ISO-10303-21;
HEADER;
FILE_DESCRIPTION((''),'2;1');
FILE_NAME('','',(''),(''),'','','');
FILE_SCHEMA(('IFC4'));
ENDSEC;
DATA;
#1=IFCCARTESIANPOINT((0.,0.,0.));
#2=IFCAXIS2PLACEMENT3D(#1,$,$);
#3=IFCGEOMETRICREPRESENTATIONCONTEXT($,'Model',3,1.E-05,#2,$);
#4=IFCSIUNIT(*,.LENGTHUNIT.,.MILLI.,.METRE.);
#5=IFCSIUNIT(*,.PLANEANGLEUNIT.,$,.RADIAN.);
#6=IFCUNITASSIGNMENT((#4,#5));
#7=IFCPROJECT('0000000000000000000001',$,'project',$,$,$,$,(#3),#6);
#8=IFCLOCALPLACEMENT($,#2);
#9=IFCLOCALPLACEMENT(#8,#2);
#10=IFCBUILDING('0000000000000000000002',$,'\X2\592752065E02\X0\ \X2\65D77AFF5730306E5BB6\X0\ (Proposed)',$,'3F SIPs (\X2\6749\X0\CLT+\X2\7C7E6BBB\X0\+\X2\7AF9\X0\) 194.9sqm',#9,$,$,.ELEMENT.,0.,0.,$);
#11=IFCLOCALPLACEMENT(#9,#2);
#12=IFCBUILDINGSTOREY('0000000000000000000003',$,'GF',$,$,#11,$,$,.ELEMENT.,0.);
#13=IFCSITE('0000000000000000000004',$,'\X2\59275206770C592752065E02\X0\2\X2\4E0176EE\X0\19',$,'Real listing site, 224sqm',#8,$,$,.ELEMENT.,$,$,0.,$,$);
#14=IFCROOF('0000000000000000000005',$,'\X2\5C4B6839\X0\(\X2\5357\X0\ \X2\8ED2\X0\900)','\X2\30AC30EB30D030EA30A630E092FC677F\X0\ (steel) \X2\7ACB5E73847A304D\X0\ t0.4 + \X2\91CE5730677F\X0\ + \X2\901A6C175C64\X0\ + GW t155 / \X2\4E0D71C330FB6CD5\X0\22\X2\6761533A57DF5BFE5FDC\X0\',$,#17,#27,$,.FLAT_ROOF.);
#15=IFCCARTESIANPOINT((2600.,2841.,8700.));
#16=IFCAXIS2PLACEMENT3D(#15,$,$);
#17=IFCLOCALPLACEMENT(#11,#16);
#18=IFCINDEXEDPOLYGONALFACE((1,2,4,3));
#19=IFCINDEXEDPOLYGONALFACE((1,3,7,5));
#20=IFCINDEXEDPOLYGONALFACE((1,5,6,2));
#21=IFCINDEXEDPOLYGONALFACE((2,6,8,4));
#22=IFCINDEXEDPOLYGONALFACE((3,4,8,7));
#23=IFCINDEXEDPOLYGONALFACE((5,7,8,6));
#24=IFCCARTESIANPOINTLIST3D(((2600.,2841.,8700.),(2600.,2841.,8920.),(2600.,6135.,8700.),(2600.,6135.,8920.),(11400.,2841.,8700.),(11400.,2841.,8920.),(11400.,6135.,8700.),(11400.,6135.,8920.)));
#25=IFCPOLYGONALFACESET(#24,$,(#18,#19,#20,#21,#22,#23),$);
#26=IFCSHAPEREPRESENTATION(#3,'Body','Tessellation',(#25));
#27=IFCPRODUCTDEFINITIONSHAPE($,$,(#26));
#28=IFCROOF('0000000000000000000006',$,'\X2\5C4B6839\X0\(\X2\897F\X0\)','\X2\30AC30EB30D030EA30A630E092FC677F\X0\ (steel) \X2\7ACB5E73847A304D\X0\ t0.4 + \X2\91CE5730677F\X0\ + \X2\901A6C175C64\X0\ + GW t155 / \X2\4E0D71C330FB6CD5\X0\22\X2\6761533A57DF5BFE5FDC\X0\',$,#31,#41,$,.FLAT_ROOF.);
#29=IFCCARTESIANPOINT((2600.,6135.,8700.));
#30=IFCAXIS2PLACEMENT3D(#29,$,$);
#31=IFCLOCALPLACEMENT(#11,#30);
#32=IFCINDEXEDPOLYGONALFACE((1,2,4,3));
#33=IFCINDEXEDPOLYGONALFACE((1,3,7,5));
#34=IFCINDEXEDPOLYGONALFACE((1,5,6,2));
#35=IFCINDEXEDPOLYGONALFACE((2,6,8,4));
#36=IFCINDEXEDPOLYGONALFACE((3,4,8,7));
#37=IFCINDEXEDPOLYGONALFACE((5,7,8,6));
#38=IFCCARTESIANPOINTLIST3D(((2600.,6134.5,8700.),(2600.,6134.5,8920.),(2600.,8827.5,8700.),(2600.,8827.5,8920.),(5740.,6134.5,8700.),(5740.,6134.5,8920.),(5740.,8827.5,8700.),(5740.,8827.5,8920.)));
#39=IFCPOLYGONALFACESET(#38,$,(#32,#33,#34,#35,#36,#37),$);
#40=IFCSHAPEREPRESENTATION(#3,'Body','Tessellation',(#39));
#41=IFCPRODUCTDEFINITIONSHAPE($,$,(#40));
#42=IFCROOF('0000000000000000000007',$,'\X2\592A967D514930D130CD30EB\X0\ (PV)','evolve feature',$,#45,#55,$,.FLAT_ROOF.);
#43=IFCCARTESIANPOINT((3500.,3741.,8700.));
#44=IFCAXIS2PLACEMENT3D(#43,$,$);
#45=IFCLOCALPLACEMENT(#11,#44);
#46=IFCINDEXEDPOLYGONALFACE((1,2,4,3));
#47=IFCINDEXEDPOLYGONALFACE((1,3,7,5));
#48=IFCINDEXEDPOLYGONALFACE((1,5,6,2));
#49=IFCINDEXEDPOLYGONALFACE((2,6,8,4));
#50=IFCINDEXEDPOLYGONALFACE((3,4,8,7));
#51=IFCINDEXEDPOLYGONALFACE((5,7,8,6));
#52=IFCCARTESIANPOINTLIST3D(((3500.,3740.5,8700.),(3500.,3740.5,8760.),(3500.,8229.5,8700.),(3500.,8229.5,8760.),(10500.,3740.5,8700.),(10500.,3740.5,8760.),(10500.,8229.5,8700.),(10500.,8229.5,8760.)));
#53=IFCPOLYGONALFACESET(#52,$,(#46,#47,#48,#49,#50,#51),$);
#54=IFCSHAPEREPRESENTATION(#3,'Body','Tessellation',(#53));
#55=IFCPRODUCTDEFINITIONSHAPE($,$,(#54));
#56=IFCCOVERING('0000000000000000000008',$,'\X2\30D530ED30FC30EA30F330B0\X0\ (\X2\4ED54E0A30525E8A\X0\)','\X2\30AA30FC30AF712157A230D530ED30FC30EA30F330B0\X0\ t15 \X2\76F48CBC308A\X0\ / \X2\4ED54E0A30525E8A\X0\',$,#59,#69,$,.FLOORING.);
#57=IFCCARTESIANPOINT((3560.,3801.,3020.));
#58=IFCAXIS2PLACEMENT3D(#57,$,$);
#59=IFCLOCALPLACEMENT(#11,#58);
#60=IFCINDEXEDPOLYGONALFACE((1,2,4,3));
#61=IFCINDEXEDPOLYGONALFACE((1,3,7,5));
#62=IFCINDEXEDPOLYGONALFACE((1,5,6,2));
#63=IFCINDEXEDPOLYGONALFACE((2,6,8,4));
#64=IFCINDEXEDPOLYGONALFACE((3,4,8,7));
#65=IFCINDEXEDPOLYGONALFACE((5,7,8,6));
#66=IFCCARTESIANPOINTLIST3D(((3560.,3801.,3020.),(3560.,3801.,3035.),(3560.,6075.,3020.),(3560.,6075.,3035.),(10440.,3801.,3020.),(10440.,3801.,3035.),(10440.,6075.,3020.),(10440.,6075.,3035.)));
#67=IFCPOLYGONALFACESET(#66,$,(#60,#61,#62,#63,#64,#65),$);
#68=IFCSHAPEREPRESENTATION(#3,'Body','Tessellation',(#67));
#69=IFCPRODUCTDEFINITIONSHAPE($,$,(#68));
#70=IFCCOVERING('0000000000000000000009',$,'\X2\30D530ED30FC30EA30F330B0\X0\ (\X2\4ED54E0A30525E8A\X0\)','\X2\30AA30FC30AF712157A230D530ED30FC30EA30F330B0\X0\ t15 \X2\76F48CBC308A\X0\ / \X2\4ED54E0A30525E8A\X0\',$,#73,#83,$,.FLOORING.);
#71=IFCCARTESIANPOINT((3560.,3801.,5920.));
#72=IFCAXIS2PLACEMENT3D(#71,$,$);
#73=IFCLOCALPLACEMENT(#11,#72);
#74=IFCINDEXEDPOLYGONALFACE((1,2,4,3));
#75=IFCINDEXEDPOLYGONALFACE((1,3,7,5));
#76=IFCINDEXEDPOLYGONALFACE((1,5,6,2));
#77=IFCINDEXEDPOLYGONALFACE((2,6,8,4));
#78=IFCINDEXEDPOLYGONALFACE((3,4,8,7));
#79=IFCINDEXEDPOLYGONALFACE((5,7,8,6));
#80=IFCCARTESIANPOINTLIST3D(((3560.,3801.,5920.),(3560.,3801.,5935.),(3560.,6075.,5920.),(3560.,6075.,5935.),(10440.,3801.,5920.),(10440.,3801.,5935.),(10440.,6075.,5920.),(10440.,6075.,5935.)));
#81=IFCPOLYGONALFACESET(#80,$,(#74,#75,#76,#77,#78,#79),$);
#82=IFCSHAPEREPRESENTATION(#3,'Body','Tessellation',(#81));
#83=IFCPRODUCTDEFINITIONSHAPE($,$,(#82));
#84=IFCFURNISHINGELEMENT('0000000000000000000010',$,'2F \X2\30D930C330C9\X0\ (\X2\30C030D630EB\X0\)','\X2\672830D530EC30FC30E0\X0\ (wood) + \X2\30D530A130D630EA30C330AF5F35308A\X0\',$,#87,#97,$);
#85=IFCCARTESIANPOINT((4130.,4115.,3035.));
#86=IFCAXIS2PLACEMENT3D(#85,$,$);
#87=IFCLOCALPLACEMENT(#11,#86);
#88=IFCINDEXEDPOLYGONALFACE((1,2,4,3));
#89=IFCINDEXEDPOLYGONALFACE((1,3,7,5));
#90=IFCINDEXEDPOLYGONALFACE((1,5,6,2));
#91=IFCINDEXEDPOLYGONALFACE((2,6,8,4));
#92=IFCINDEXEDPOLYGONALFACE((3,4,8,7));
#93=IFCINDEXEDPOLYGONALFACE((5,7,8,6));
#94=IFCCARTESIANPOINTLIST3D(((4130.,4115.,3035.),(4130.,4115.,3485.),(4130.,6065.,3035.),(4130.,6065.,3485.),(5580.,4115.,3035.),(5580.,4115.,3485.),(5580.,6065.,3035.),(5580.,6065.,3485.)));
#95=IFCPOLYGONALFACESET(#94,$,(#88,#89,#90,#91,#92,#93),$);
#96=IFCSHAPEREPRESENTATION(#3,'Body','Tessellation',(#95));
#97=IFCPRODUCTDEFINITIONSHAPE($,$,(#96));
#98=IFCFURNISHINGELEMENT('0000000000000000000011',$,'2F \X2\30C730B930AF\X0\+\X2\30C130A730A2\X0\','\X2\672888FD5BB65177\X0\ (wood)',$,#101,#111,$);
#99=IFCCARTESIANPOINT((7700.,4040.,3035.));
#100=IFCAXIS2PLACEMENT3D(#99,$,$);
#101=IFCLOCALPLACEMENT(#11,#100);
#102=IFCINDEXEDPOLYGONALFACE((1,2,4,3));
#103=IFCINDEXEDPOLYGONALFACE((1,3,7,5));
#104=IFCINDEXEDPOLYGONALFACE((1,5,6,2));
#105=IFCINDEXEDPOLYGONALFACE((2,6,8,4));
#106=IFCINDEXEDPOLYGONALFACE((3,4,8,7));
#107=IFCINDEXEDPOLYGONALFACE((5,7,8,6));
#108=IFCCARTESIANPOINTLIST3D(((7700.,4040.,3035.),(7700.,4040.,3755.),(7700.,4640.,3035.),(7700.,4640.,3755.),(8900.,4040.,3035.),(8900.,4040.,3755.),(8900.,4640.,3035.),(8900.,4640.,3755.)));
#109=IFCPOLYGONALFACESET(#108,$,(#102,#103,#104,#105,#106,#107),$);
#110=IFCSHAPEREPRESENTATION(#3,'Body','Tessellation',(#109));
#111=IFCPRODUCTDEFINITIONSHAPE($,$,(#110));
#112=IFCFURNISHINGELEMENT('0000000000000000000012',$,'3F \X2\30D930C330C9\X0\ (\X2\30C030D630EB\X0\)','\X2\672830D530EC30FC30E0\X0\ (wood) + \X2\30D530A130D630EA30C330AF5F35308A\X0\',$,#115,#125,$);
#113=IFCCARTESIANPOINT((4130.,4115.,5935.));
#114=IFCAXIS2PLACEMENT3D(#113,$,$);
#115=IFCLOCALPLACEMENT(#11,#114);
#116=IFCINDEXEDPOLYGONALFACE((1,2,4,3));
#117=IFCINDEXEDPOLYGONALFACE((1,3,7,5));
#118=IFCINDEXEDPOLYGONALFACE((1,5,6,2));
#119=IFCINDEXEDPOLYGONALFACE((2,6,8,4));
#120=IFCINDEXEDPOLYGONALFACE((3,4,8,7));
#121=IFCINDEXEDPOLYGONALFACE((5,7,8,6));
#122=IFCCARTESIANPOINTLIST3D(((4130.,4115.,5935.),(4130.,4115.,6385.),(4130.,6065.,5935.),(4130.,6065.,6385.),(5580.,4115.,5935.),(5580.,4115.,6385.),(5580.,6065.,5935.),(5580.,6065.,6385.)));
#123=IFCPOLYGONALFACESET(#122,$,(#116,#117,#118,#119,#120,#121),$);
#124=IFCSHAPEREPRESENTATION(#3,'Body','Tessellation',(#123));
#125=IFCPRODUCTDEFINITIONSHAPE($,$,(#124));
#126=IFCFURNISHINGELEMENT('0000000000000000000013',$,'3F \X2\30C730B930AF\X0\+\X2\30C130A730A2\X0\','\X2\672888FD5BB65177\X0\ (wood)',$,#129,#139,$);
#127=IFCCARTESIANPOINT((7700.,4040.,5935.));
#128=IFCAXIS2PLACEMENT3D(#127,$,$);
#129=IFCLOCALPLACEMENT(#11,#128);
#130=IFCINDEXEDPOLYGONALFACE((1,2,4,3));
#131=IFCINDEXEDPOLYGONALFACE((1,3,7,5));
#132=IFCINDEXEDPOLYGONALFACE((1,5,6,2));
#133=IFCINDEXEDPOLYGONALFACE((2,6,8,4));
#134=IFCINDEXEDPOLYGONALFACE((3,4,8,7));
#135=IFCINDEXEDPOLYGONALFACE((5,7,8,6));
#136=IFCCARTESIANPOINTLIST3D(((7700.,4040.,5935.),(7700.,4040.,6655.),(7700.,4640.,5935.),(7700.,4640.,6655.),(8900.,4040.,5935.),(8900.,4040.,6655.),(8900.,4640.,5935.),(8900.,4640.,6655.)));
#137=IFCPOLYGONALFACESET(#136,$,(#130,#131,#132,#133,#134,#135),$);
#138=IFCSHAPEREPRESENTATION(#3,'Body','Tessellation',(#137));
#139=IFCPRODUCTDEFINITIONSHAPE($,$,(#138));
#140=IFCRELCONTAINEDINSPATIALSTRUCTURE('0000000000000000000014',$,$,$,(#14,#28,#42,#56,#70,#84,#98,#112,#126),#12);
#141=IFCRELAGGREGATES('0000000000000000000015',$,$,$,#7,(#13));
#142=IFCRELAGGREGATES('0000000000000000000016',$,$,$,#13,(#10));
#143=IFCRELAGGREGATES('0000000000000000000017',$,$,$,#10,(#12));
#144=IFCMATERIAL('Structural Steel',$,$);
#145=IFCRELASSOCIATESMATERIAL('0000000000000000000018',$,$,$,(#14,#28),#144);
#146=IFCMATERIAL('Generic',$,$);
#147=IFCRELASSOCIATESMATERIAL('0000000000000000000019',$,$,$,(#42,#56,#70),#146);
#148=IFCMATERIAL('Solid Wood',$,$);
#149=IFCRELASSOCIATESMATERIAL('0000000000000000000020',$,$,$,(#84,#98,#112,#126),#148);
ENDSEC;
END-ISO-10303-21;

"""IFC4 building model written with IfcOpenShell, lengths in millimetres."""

from ifc_helpers import new_model, si_unit, frame, frame_2d, origin, place, context, project, spatial, rectangle, extrude, material, element, save


model = new_model("IFC4")

# Units and contexts
model_context = context("Model", 3, precision=1e-05, world=origin())
ifc_project = project(units=[si_unit("LENGTHUNIT", "METRE", prefix="MILLI"), si_unit("PLANEANGLEUNIT", "RADIAN")], contexts=[model_context])

# Site, building, storey
site_placement = place(None, origin())
site = spatial("IfcSite", under=ifc_project, at=site_placement, Name="大分県大分市2丁目19", ObjectType="Real listing site, 224sqm", CompositionType="ELEMENT", RefElevation=0.0)
building_placement = place(site_placement, origin())
building = spatial("IfcBuilding", under=site, at=building_placement, Name="大分市 旗竿地の家 (Proposed)", ObjectType="3F SIPs (杉CLT+籾殻+竹) 194.9sqm", CompositionType="ELEMENT", ElevationOfRefHeight=0.0, ElevationOfTerrain=0.0)
storey_placement = place(building_placement, origin())
storey = spatial("IfcBuildingStorey", under=building, at=storey_placement, Name="GF", CompositionType="ELEMENT", Elevation=0.0)

# Shared definitions
ifc_material_1 = material(Name="Solid Wood")

# Roofs
ifc_material_2 = material(Name="Structural Steel")
roof_1_placement = place(storey_placement, frame((2600.0, 2841.0, 8700.0)))
element("IfcRoof", 1, at=roof_1_placement, inside=storey, material=ifc_material_2, Name="屋根(南 軒900)", Description="ガルバリウム鋼板 (steel) 立平葺き t0.4 + 野地板 + 通気層 + GW t155 / 不燃・法22条区域対応", PredefinedType="FLAT_ROOF", context=model_context, shape_type="SweptSolid", body=[
    extrude(rectangle(XDim=8800.0, YDim=3294.0, at=frame_2d((4400.0, 1647.0))), frame((2600.0, 2841.0, 8700.0)), (0.0, 0.0, 1.0), 220.0),
])
roof_2_placement = place(storey_placement, frame((2600.0, 6135.0, 8700.0)))
element("IfcRoof", 2, at=roof_2_placement, inside=storey, material=ifc_material_2, Name="屋根(西)", Description="ガルバリウム鋼板 (steel) 立平葺き t0.4 + 野地板 + 通気層 + GW t155 / 不燃・法22条区域対応", PredefinedType="FLAT_ROOF", context=model_context, shape_type="SweptSolid", body=[
    extrude(rectangle(XDim=3140.0, YDim=2693.0, at=frame_2d((1570.0, 1346.0))), frame((2600.0, 6135.0, 8700.0)), (0.0, 0.0, 1.0), 220.0),
])
ifc_material_3 = material(Name="Generic")
roof_3_placement = place(storey_placement, frame((3500.0, 3741.0, 8700.0)))
element("IfcRoof", 3, at=roof_3_placement, inside=storey, material=ifc_material_3, Name="太陽光パネル (PV)", Description="evolve feature", PredefinedType="FLAT_ROOF", context=model_context, shape_type="SweptSolid", body=[
    extrude(rectangle(XDim=7000.0, YDim=4489.0, at=frame_2d((3500.0, 2244.0))), frame((3500.0, 3741.0, 8700.0)), (0.0, 0.0, 1.0), 60.0),
])

# Coverings
covering_1_placement = place(storey_placement, frame((3560.0, 3801.0, 3020.0)))
element("IfcCovering", 4, at=covering_1_placement, inside=storey, material=ifc_material_3, Name="フローリング (仕上げ床)", Description="オーク無垢フローリング t15 直貼り / 仕上げ床", PredefinedType="FLOORING", context=model_context, shape_type="SweptSolid", body=[
    extrude(rectangle(XDim=6880.0, YDim=2274.0, at=frame_2d((3440.0, 1137.0))), frame((3560.0, 3801.0, 3020.0)), (0.0, 0.0, 1.0), 15.0),
])
covering_2_placement = place(storey_placement, frame((3560.0, 3801.0, 5920.0)))
element("IfcCovering", 5, at=covering_2_placement, inside=storey, material=ifc_material_3, Name="フローリング (仕上げ床)", Description="オーク無垢フローリング t15 直貼り / 仕上げ床", PredefinedType="FLOORING", context=model_context, shape_type="SweptSolid", body=[
    extrude(rectangle(XDim=6880.0, YDim=2274.0, at=frame_2d((3440.0, 1137.0))), frame((3560.0, 3801.0, 5920.0)), (0.0, 0.0, 1.0), 15.0),
])

# Furnishing elements
furnishing_1_placement = place(storey_placement, frame((4130.0, 4115.0, 3035.0)))
element("IfcFurnishingElement", 6, at=furnishing_1_placement, inside=storey, material=ifc_material_1, Name="2F ベッド (ダブル)", Description="木フレーム (wood) + ファブリック張り", context=model_context, shape_type="SweptSolid", body=[
    extrude(rectangle(XDim=1450.0, YDim=1950.0, at=frame_2d((725.0, 975.0))), frame((4130.0, 4115.0, 3035.0)), (0.0, 0.0, 1.0), 450.0),
])
furnishing_2_placement = place(storey_placement, frame((7700.0, 4040.0, 3035.0)))
element("IfcFurnishingElement", 7, at=furnishing_2_placement, inside=storey, material=ifc_material_1, Name="2F デスク+チェア", Description="木製家具 (wood)", context=model_context, shape_type="SweptSolid", body=[
    extrude(rectangle(XDim=1200.0, YDim=600.0, at=frame_2d((600.0, 300.0))), frame((7700.0, 4040.0, 3035.0)), (0.0, 0.0, 1.0), 720.0),
])
furnishing_3_placement = place(storey_placement, frame((4130.0, 4115.0, 5935.0)))
element("IfcFurnishingElement", 8, at=furnishing_3_placement, inside=storey, material=ifc_material_1, Name="3F ベッド (ダブル)", Description="木フレーム (wood) + ファブリック張り", context=model_context, shape_type="SweptSolid", body=[
    extrude(rectangle(XDim=1450.0, YDim=1950.0, at=frame_2d((725.0, 975.0))), frame((4130.0, 4115.0, 5935.0)), (0.0, 0.0, 1.0), 450.0),
])
furnishing_4_placement = place(storey_placement, frame((7700.0, 4040.0, 5935.0)))
element("IfcFurnishingElement", 9, at=furnishing_4_placement, inside=storey, material=ifc_material_1, Name="3F デスク+チェア", Description="木製家具 (wood)", context=model_context, shape_type="SweptSolid", body=[
    extrude(rectangle(XDim=1200.0, YDim=600.0, at=frame_2d((600.0, 300.0))), frame((7700.0, 4040.0, 5935.0)), (0.0, 0.0, 1.0), 720.0),
])

save(model, "model.ifc")
